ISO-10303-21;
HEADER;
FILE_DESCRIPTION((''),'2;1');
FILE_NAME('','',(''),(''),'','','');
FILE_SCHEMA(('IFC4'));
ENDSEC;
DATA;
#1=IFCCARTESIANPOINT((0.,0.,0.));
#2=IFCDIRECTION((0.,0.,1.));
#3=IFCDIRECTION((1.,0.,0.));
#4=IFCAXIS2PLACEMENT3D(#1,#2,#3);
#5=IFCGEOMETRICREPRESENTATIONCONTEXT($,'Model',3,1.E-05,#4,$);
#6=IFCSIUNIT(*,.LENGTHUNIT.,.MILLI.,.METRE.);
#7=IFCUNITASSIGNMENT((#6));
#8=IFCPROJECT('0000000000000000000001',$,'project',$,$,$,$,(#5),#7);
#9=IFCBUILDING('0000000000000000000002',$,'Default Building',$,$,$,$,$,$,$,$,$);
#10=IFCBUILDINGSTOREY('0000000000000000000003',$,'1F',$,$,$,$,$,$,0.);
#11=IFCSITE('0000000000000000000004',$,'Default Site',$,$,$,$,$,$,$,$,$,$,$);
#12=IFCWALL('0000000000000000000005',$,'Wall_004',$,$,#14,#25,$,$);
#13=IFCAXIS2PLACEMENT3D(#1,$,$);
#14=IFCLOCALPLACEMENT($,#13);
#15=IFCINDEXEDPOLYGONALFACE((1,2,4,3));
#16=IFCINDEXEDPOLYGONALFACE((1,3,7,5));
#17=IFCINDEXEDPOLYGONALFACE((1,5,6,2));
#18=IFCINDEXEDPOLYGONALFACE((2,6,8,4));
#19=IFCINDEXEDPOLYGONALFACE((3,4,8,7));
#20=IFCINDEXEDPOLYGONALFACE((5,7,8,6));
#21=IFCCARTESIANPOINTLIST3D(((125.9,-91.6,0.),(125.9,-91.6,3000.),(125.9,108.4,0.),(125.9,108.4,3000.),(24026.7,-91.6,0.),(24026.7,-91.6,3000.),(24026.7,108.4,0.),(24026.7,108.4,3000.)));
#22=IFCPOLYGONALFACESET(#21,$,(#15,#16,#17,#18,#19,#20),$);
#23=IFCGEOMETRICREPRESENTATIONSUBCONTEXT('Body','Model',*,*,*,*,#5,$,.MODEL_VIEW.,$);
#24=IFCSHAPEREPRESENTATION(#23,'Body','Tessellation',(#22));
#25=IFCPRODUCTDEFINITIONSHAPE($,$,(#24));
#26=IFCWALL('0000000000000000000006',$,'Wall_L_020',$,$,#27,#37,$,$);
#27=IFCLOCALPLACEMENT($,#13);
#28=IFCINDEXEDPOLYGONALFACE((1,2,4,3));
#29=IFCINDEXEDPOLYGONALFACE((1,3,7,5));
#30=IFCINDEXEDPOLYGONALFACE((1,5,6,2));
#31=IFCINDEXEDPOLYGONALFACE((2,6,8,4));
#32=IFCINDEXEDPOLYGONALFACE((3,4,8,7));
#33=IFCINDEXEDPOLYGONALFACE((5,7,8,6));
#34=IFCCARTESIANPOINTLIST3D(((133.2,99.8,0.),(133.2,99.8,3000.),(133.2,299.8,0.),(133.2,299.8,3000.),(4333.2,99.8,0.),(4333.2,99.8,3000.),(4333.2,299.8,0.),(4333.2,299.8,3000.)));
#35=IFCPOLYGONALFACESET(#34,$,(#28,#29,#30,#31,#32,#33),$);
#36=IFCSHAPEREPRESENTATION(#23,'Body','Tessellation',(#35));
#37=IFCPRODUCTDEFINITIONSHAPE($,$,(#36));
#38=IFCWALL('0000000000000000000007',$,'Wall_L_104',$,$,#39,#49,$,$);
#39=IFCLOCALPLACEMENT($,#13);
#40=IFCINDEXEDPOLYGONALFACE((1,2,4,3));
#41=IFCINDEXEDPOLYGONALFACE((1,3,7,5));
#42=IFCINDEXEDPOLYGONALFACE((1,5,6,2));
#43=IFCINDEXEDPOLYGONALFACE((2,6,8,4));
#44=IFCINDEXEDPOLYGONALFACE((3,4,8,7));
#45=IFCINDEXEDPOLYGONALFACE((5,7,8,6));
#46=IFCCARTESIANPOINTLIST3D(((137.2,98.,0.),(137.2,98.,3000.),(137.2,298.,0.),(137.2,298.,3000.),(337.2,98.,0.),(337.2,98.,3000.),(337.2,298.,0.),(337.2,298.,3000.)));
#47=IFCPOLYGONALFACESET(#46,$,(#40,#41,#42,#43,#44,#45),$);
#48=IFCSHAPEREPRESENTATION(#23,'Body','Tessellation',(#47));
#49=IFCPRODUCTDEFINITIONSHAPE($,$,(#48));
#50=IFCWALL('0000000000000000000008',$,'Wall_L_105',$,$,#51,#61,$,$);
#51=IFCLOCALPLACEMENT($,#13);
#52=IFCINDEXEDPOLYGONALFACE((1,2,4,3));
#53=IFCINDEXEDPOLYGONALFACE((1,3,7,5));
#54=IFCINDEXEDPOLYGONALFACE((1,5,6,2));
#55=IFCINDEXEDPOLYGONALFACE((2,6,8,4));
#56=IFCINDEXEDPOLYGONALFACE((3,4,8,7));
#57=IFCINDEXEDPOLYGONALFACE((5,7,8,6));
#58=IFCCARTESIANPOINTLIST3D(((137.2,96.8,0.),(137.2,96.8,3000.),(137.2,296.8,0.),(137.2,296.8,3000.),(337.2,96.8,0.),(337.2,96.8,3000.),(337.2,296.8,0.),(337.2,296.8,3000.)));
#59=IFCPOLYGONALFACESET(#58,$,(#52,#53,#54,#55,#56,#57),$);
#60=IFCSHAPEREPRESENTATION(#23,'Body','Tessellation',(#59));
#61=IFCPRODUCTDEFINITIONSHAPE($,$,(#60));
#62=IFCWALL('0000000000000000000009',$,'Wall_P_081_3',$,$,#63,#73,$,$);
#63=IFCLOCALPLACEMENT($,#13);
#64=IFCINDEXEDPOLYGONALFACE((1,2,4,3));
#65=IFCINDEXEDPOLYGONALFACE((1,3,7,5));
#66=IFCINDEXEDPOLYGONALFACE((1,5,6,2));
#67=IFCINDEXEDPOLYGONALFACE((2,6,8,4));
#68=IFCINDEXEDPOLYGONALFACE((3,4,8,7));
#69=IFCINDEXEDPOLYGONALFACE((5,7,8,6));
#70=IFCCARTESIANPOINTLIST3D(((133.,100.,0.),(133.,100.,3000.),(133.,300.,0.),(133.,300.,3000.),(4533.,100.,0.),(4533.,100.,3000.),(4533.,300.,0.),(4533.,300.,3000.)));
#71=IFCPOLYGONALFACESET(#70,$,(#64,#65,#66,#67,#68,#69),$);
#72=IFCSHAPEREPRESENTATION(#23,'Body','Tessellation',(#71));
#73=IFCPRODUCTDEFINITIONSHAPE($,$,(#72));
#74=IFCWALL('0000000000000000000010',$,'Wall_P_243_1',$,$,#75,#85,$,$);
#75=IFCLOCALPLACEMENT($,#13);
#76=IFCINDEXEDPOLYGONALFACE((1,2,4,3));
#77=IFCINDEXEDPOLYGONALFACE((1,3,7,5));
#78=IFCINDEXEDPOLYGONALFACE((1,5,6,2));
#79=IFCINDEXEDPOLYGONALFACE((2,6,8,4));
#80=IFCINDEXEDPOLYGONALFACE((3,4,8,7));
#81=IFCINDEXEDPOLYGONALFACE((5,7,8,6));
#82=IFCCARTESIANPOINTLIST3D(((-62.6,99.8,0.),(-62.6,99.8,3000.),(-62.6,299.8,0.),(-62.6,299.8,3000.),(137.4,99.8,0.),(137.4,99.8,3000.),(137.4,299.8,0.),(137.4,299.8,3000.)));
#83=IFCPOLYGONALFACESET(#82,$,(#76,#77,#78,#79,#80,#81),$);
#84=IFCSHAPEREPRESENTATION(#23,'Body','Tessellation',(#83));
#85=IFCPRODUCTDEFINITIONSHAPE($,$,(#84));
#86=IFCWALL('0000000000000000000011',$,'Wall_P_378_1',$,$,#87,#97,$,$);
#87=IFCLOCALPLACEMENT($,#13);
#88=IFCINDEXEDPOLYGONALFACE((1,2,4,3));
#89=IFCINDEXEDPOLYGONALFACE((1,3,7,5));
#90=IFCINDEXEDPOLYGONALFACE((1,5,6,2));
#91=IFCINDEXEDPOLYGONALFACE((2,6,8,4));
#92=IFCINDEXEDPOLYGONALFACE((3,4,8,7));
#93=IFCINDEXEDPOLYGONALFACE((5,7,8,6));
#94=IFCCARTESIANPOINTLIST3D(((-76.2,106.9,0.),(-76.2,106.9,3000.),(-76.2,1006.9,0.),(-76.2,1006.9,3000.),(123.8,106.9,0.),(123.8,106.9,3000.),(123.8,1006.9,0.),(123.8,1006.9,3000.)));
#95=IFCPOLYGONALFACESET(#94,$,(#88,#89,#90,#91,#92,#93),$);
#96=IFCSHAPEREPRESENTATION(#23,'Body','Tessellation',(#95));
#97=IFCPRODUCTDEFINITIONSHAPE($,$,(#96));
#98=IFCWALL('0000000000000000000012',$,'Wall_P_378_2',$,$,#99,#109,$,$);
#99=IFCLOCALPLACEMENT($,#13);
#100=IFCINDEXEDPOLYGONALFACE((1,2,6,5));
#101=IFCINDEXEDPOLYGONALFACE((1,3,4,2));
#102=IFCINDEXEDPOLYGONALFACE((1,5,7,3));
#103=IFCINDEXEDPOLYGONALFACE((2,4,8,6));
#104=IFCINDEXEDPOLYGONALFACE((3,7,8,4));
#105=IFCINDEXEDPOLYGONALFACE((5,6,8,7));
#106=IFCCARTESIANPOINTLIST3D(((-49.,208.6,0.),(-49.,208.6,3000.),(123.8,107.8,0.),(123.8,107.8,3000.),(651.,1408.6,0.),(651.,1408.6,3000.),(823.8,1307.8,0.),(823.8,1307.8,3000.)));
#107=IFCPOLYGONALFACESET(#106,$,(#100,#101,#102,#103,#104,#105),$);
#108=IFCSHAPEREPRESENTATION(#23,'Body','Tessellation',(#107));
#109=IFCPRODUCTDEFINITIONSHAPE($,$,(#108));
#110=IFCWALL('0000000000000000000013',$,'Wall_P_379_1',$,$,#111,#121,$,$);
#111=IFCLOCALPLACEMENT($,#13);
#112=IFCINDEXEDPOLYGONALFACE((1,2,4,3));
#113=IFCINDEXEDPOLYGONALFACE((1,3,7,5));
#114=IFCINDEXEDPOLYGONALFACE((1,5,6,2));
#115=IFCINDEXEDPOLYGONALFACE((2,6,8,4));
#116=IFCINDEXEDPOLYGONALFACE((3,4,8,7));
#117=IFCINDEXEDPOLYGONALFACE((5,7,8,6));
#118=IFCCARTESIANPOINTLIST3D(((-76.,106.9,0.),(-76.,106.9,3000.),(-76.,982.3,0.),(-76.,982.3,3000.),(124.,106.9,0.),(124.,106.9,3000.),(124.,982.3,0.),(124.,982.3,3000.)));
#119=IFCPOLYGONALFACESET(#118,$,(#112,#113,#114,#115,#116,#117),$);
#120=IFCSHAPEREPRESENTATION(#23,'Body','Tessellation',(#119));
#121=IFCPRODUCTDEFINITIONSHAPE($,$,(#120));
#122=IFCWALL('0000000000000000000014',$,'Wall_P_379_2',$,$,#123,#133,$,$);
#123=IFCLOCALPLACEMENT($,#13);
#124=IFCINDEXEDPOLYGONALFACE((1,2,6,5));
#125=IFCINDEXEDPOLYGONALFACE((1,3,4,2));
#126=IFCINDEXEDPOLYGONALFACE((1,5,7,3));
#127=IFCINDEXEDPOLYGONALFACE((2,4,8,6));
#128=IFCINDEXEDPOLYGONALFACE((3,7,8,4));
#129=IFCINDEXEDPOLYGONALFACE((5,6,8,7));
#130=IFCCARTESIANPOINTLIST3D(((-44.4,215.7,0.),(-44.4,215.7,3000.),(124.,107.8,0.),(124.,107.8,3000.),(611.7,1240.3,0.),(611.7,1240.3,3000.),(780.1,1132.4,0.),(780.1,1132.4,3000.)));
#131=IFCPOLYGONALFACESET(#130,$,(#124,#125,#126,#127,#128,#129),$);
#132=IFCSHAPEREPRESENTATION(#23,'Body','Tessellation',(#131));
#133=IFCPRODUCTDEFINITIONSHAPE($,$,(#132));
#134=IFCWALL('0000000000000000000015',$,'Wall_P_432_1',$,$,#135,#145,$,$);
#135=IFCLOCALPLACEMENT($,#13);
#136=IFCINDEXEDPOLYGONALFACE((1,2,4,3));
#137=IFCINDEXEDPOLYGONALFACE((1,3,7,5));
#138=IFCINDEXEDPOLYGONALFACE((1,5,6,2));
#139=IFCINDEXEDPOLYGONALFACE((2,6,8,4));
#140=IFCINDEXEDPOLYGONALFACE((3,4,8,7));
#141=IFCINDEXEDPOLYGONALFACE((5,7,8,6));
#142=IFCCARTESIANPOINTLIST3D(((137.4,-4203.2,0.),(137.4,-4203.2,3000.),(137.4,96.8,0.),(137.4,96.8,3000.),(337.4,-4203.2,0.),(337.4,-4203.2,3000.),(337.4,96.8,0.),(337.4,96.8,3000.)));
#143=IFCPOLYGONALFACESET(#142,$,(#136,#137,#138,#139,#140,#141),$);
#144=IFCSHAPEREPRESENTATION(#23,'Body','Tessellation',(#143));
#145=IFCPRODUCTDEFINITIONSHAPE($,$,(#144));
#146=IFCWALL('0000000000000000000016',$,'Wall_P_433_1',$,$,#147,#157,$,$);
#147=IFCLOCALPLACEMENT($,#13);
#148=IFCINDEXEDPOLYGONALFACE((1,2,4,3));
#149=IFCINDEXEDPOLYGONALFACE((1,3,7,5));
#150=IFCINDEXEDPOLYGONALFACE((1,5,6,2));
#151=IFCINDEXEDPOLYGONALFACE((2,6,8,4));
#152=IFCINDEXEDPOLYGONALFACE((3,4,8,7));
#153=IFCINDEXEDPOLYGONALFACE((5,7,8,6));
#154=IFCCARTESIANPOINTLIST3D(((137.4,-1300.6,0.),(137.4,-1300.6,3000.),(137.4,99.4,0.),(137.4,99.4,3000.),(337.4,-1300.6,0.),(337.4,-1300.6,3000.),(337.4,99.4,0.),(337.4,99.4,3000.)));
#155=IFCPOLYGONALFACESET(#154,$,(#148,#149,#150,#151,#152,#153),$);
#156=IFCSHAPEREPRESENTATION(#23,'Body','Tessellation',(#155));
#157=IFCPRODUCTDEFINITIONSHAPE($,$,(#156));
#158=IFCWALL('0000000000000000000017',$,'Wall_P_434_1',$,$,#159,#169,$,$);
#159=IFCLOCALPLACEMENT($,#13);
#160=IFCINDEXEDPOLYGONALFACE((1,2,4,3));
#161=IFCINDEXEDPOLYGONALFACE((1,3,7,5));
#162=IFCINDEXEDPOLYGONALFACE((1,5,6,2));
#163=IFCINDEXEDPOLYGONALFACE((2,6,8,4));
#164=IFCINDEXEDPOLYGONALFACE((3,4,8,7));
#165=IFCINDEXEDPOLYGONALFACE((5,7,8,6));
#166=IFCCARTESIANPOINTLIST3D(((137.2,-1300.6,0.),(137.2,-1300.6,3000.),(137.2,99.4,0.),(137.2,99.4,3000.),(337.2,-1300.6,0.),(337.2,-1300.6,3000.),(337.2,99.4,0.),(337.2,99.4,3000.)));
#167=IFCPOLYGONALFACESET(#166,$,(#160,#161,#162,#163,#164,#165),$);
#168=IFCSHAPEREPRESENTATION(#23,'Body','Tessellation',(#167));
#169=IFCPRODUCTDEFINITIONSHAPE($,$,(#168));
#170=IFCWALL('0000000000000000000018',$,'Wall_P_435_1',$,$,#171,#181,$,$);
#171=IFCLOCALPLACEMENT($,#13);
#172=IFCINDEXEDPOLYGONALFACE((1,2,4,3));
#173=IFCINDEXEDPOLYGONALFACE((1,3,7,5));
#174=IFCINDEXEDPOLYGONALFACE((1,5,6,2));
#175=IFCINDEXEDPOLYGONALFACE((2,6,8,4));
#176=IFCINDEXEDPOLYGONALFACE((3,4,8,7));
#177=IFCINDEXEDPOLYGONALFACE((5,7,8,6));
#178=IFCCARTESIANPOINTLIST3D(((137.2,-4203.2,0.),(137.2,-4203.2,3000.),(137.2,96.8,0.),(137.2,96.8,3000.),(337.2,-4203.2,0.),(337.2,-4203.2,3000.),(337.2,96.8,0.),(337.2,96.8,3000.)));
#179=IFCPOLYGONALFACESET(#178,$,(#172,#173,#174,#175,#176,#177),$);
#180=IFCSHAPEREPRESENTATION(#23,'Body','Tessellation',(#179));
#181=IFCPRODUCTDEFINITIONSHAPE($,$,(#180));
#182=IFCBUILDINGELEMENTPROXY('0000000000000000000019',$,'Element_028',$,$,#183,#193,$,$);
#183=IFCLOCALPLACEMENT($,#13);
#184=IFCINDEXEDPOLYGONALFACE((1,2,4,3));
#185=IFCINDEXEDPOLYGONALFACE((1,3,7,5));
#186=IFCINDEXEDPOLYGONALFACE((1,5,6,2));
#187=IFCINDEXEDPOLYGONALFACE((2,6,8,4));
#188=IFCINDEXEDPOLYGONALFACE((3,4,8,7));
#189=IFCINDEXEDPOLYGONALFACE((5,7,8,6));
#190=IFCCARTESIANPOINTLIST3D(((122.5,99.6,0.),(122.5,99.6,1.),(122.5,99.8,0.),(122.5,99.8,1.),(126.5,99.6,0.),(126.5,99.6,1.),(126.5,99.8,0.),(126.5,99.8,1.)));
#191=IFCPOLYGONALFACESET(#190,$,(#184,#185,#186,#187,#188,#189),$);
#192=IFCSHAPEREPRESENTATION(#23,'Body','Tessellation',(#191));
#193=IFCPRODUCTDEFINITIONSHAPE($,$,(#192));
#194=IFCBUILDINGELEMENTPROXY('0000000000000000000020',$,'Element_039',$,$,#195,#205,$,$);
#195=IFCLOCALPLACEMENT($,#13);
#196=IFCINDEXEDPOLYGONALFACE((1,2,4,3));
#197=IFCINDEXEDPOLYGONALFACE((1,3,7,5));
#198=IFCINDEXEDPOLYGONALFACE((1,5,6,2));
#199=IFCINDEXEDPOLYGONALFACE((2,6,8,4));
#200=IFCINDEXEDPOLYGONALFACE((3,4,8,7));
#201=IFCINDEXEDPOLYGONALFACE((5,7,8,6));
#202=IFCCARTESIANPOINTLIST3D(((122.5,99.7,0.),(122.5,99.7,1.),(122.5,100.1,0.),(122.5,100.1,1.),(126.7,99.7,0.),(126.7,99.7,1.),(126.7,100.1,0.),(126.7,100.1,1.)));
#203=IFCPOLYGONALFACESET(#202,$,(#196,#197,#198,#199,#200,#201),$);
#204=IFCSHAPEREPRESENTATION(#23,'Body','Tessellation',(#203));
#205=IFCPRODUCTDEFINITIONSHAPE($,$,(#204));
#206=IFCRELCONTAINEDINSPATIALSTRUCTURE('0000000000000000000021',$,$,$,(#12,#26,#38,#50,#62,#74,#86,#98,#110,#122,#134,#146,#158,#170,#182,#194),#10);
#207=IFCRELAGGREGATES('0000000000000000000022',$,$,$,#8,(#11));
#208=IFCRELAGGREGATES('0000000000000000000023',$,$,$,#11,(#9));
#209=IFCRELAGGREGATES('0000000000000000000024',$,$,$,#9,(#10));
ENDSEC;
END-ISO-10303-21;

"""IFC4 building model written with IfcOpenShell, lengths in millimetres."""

from ifc_helpers import new_model, si_unit, frame, origin, origin_with_axes, place, context, subcontext, project, spatial, indexed_curve, rectangle, outline, extrude, element, save


model = new_model("IFC4")

# Units and contexts
model_context = context("Model", 3, precision=1e-05, world=origin_with_axes())
body_context = subcontext(model_context, "Body", "Model", "MODEL_VIEW")
ifc_project = project(units=[si_unit("LENGTHUNIT", "METRE", prefix="MILLI")], contexts=[model_context])

# Site, building, storey
site = spatial("IfcSite", under=ifc_project, Name="Default Site")
building = spatial("IfcBuilding", under=site, Name="Default Building")
storey = spatial("IfcBuildingStorey", under=building, Name="1F", Elevation=0.0)

# Walls
wall_1_placement = place(None, frame((125.9, 108.4, 0.0), z_axis=(0.0, 0.0, 1.0), x_axis=(0.0, -1.0, 0.0)))
element("IfcWall", 1, at=wall_1_placement, inside=storey, Name="Wall_004", context=body_context, shape_type="SweptSolid", body=[
    extrude(outline(indexed_curve([(0.0, 0.0), (0.0, 23900.8), (200.0, 23900.8), (200.0, 0.0), (0.0, 0.0)], self_intersect=False)), origin_with_axes(), (0.0, 0.0, 1.0), 3000.0),
])
wall_2_placement = place(None, frame((133.2, 99.8, 0.0), z_axis=(0.0, 0.0, 1.0), x_axis=(1.0, 0.0, 0.0)))
element("IfcWall", 2, at=wall_2_placement, inside=storey, Name="Wall_L_020", context=body_context, shape_type="SweptSolid", body=[
    extrude(outline(indexed_curve([(0.0, 0.0), (0.0, 200.0), (4200.0, 200.0), (4200.0, 0.0), (0.0, 0.0)], self_intersect=False)), origin_with_axes(), (0.0, 0.0, 1.0), 3000.0),
])
for number, where, z_axis, x_axis, name in (
    (3, (137.2, 98.0, 0.0), (0.0, 0.0, 1.0), (1.0, 0.0, 0.0), "Wall_L_104"),
    (4, (137.2, 96.8, 0.0), (0.0, 0.0, 1.0), (1.0, 0.0, 0.0), "Wall_L_105"),
):
    element("IfcWall", number, at=place(None, frame(where, z_axis=z_axis, x_axis=x_axis)), inside=storey, Name=name, context=body_context, shape_type="SweptSolid", body=[
        extrude(outline(indexed_curve([(0.0, 0.0), (0.0, 200.0), (200.0, 200.0), (200.0, 0.0), (0.0, 0.0)], self_intersect=False)), origin_with_axes(), (0.0, 0.0, 1.0), 3000.0),
    ])
wall_3_placement = place(None, frame((133.0, 100.0, 0.0), z_axis=(0.0, 0.0, 1.0), x_axis=(1.0, 0.0, 0.0)))
element("IfcWall", 5, at=wall_3_placement, inside=storey, Name="Wall_P_081_3", context=body_context, shape_type="SweptSolid", body=[
    extrude(outline(indexed_curve([(0.0, 0.0), (0.0, 200.0), (4400.0, 200.0), (4400.0, 0.0), (0.0, 0.0)], self_intersect=False)), origin_with_axes(), (0.0, 0.0, 1.0), 3000.0),
])
wall_4_placement = place(None, frame((137.4, 99.8, 0.0), z_axis=(0.0, 0.0, 1.0), x_axis=(0.0, 1.0, 0.0)))
element("IfcWall", 6, at=wall_4_placement, inside=storey, Name="Wall_P_243_1", context=body_context, shape_type="SweptSolid", body=[
    extrude(outline(indexed_curve([(0.0, 0.0), (0.0, 200.0), (200.0, 200.0), (200.0, 0.0), (0.0, 0.0)], self_intersect=False)), origin_with_axes(), (0.0, 0.0, 1.0), 3000.0),
])
wall_5_placement = place(None, frame((123.8, 106.9, 0.0), z_axis=(0.0, 0.0, 1.0), x_axis=(0.0, 1.0, 0.0)))
element("IfcWall", 7, at=wall_5_placement, inside=storey, Name="Wall_P_378_1", context=body_context, shape_type="SweptSolid", body=[
    extrude(outline(indexed_curve([(0.0, 0.0), (0.0, 200.0), (900.0, 200.0), (900.0, 0.0), (0.0, 0.0)], self_intersect=False)), origin_with_axes(), (0.0, 0.0, 1.0), 3000.0),
])
wall_6_placement = place(None, frame((123.8, 107.8, 0.0), z_axis=(0.0, 0.0, 1.0), x_axis=(0.503871, 0.863779, 0.0)))
element("IfcWall", 8, at=wall_6_placement, inside=storey, Name="Wall_P_378_2", context=body_context, shape_type="SweptSolid", body=[
    extrude(outline(indexed_curve([(0.0, 0.0), (0.0, 200.0), (1389.2, 200.0), (1389.2, 0.0), (0.0, 0.0)], self_intersect=False)), origin_with_axes(), (0.0, 0.0, 1.0), 3000.0),
])
wall_7_placement = place(None, frame((124.0, 106.9, 0.0), z_axis=(0.0, 0.0, 1.0), x_axis=(0.0, 1.0, 0.0)))
element("IfcWall", 9, at=wall_7_placement, inside=storey, Name="Wall_P_379_1", context=body_context, shape_type="SweptSolid", body=[
    extrude(outline(indexed_curve([(0.0, 0.0), (0.0, 200.0), (875.4, 200.0), (875.4, 0.0), (0.0, 0.0)], self_intersect=False)), origin_with_axes(), (0.0, 0.0, 1.0), 3000.0),
])
wall_8_placement = place(None, frame((124.0, 107.8, 0.0), z_axis=(0.0, 0.0, 1.0), x_axis=(0.539286, 0.842123, 0.0)))
element("IfcWall", 10, at=wall_8_placement, inside=storey, Name="Wall_P_379_2", context=body_context, shape_type="SweptSolid", body=[
    extrude(outline(indexed_curve([(0.0, 0.0), (0.0, 200.0), (1216.7, 200.0), (1216.7, 0.0), (0.0, 0.0)], self_intersect=False)), origin_with_axes(), (0.0, 0.0, 1.0), 3000.0),
])
wall_9_placement = place(None, frame((137.4, 96.8, 0.0), z_axis=(0.0, 0.0, 1.0), x_axis=(0.0, -1.0, 0.0)))
element("IfcWall", 11, at=wall_9_placement, inside=storey, Name="Wall_P_432_1", context=body_context, shape_type="SweptSolid", body=[
    extrude(outline(indexed_curve([(0.0, 0.0), (0.0, 200.0), (4300.0, 200.0), (4300.0, 0.0), (0.0, 0.0)], self_intersect=False)), origin_with_axes(), (0.0, 0.0, 1.0), 3000.0),
])
for number, where, z_axis, x_axis, name in (
    (12, (137.4, 99.4, 0.0), (0.0, 0.0, 1.0), (0.0, -1.0, 0.0), "Wall_P_433_1"),
    (13, (137.2, 99.4, 0.0), (0.0, 0.0, 1.0), (0.0, -1.0, 0.0), "Wall_P_434_1"),
):
    element("IfcWall", number, at=place(None, frame(where, z_axis=z_axis, x_axis=x_axis)), inside=storey, Name=name, context=body_context, shape_type="SweptSolid", body=[
        extrude(outline(indexed_curve([(0.0, 0.0), (0.0, 200.0), (1400.0, 200.0), (1400.0, 0.0), (0.0, 0.0)], self_intersect=False)), origin_with_axes(), (0.0, 0.0, 1.0), 3000.0),
    ])
wall_10_placement = place(None, frame((137.2, 96.8, 0.0), z_axis=(0.0, 0.0, 1.0), x_axis=(0.0, -1.0, 0.0)))
element("IfcWall", 14, at=wall_10_placement, inside=storey, Name="Wall_P_435_1", context=body_context, shape_type="SweptSolid", body=[
    extrude(outline(indexed_curve([(0.0, 0.0), (0.0, 200.0), (4300.0, 200.0), (4300.0, 0.0), (0.0, 0.0)], self_intersect=False)), origin_with_axes(), (0.0, 0.0, 1.0), 3000.0),
])

# Building element proxies
proxy_1_placement = place(None, frame((124.5, 99.7, 0.0), z_axis=(0.0, 0.0, 1.0), x_axis=(1.0, 0.0, 0.0)))
element("IfcBuildingElementProxy", 15, at=proxy_1_placement, inside=storey, Name="Element_028", context=body_context, shape_type="SweptSolid", body=[
    extrude(rectangle(XDim=4.0, YDim=0.2), origin(), (0.0, 0.0, 1.0), 1.0),
])
proxy_2_placement = place(None, frame((124.6, 99.9, 0.0), z_axis=(0.0, 0.0, 1.0), x_axis=(1.0, 0.0, 0.0)))
element("IfcBuildingElementProxy", 16, at=proxy_2_placement, inside=storey, Name="Element_039", context=body_context, shape_type="SweptSolid", body=[
    extrude(rectangle(XDim=4.2, YDim=0.4), origin(), (0.0, 0.0, 1.0), 1.0),
])

save(model, "model.ifc")
